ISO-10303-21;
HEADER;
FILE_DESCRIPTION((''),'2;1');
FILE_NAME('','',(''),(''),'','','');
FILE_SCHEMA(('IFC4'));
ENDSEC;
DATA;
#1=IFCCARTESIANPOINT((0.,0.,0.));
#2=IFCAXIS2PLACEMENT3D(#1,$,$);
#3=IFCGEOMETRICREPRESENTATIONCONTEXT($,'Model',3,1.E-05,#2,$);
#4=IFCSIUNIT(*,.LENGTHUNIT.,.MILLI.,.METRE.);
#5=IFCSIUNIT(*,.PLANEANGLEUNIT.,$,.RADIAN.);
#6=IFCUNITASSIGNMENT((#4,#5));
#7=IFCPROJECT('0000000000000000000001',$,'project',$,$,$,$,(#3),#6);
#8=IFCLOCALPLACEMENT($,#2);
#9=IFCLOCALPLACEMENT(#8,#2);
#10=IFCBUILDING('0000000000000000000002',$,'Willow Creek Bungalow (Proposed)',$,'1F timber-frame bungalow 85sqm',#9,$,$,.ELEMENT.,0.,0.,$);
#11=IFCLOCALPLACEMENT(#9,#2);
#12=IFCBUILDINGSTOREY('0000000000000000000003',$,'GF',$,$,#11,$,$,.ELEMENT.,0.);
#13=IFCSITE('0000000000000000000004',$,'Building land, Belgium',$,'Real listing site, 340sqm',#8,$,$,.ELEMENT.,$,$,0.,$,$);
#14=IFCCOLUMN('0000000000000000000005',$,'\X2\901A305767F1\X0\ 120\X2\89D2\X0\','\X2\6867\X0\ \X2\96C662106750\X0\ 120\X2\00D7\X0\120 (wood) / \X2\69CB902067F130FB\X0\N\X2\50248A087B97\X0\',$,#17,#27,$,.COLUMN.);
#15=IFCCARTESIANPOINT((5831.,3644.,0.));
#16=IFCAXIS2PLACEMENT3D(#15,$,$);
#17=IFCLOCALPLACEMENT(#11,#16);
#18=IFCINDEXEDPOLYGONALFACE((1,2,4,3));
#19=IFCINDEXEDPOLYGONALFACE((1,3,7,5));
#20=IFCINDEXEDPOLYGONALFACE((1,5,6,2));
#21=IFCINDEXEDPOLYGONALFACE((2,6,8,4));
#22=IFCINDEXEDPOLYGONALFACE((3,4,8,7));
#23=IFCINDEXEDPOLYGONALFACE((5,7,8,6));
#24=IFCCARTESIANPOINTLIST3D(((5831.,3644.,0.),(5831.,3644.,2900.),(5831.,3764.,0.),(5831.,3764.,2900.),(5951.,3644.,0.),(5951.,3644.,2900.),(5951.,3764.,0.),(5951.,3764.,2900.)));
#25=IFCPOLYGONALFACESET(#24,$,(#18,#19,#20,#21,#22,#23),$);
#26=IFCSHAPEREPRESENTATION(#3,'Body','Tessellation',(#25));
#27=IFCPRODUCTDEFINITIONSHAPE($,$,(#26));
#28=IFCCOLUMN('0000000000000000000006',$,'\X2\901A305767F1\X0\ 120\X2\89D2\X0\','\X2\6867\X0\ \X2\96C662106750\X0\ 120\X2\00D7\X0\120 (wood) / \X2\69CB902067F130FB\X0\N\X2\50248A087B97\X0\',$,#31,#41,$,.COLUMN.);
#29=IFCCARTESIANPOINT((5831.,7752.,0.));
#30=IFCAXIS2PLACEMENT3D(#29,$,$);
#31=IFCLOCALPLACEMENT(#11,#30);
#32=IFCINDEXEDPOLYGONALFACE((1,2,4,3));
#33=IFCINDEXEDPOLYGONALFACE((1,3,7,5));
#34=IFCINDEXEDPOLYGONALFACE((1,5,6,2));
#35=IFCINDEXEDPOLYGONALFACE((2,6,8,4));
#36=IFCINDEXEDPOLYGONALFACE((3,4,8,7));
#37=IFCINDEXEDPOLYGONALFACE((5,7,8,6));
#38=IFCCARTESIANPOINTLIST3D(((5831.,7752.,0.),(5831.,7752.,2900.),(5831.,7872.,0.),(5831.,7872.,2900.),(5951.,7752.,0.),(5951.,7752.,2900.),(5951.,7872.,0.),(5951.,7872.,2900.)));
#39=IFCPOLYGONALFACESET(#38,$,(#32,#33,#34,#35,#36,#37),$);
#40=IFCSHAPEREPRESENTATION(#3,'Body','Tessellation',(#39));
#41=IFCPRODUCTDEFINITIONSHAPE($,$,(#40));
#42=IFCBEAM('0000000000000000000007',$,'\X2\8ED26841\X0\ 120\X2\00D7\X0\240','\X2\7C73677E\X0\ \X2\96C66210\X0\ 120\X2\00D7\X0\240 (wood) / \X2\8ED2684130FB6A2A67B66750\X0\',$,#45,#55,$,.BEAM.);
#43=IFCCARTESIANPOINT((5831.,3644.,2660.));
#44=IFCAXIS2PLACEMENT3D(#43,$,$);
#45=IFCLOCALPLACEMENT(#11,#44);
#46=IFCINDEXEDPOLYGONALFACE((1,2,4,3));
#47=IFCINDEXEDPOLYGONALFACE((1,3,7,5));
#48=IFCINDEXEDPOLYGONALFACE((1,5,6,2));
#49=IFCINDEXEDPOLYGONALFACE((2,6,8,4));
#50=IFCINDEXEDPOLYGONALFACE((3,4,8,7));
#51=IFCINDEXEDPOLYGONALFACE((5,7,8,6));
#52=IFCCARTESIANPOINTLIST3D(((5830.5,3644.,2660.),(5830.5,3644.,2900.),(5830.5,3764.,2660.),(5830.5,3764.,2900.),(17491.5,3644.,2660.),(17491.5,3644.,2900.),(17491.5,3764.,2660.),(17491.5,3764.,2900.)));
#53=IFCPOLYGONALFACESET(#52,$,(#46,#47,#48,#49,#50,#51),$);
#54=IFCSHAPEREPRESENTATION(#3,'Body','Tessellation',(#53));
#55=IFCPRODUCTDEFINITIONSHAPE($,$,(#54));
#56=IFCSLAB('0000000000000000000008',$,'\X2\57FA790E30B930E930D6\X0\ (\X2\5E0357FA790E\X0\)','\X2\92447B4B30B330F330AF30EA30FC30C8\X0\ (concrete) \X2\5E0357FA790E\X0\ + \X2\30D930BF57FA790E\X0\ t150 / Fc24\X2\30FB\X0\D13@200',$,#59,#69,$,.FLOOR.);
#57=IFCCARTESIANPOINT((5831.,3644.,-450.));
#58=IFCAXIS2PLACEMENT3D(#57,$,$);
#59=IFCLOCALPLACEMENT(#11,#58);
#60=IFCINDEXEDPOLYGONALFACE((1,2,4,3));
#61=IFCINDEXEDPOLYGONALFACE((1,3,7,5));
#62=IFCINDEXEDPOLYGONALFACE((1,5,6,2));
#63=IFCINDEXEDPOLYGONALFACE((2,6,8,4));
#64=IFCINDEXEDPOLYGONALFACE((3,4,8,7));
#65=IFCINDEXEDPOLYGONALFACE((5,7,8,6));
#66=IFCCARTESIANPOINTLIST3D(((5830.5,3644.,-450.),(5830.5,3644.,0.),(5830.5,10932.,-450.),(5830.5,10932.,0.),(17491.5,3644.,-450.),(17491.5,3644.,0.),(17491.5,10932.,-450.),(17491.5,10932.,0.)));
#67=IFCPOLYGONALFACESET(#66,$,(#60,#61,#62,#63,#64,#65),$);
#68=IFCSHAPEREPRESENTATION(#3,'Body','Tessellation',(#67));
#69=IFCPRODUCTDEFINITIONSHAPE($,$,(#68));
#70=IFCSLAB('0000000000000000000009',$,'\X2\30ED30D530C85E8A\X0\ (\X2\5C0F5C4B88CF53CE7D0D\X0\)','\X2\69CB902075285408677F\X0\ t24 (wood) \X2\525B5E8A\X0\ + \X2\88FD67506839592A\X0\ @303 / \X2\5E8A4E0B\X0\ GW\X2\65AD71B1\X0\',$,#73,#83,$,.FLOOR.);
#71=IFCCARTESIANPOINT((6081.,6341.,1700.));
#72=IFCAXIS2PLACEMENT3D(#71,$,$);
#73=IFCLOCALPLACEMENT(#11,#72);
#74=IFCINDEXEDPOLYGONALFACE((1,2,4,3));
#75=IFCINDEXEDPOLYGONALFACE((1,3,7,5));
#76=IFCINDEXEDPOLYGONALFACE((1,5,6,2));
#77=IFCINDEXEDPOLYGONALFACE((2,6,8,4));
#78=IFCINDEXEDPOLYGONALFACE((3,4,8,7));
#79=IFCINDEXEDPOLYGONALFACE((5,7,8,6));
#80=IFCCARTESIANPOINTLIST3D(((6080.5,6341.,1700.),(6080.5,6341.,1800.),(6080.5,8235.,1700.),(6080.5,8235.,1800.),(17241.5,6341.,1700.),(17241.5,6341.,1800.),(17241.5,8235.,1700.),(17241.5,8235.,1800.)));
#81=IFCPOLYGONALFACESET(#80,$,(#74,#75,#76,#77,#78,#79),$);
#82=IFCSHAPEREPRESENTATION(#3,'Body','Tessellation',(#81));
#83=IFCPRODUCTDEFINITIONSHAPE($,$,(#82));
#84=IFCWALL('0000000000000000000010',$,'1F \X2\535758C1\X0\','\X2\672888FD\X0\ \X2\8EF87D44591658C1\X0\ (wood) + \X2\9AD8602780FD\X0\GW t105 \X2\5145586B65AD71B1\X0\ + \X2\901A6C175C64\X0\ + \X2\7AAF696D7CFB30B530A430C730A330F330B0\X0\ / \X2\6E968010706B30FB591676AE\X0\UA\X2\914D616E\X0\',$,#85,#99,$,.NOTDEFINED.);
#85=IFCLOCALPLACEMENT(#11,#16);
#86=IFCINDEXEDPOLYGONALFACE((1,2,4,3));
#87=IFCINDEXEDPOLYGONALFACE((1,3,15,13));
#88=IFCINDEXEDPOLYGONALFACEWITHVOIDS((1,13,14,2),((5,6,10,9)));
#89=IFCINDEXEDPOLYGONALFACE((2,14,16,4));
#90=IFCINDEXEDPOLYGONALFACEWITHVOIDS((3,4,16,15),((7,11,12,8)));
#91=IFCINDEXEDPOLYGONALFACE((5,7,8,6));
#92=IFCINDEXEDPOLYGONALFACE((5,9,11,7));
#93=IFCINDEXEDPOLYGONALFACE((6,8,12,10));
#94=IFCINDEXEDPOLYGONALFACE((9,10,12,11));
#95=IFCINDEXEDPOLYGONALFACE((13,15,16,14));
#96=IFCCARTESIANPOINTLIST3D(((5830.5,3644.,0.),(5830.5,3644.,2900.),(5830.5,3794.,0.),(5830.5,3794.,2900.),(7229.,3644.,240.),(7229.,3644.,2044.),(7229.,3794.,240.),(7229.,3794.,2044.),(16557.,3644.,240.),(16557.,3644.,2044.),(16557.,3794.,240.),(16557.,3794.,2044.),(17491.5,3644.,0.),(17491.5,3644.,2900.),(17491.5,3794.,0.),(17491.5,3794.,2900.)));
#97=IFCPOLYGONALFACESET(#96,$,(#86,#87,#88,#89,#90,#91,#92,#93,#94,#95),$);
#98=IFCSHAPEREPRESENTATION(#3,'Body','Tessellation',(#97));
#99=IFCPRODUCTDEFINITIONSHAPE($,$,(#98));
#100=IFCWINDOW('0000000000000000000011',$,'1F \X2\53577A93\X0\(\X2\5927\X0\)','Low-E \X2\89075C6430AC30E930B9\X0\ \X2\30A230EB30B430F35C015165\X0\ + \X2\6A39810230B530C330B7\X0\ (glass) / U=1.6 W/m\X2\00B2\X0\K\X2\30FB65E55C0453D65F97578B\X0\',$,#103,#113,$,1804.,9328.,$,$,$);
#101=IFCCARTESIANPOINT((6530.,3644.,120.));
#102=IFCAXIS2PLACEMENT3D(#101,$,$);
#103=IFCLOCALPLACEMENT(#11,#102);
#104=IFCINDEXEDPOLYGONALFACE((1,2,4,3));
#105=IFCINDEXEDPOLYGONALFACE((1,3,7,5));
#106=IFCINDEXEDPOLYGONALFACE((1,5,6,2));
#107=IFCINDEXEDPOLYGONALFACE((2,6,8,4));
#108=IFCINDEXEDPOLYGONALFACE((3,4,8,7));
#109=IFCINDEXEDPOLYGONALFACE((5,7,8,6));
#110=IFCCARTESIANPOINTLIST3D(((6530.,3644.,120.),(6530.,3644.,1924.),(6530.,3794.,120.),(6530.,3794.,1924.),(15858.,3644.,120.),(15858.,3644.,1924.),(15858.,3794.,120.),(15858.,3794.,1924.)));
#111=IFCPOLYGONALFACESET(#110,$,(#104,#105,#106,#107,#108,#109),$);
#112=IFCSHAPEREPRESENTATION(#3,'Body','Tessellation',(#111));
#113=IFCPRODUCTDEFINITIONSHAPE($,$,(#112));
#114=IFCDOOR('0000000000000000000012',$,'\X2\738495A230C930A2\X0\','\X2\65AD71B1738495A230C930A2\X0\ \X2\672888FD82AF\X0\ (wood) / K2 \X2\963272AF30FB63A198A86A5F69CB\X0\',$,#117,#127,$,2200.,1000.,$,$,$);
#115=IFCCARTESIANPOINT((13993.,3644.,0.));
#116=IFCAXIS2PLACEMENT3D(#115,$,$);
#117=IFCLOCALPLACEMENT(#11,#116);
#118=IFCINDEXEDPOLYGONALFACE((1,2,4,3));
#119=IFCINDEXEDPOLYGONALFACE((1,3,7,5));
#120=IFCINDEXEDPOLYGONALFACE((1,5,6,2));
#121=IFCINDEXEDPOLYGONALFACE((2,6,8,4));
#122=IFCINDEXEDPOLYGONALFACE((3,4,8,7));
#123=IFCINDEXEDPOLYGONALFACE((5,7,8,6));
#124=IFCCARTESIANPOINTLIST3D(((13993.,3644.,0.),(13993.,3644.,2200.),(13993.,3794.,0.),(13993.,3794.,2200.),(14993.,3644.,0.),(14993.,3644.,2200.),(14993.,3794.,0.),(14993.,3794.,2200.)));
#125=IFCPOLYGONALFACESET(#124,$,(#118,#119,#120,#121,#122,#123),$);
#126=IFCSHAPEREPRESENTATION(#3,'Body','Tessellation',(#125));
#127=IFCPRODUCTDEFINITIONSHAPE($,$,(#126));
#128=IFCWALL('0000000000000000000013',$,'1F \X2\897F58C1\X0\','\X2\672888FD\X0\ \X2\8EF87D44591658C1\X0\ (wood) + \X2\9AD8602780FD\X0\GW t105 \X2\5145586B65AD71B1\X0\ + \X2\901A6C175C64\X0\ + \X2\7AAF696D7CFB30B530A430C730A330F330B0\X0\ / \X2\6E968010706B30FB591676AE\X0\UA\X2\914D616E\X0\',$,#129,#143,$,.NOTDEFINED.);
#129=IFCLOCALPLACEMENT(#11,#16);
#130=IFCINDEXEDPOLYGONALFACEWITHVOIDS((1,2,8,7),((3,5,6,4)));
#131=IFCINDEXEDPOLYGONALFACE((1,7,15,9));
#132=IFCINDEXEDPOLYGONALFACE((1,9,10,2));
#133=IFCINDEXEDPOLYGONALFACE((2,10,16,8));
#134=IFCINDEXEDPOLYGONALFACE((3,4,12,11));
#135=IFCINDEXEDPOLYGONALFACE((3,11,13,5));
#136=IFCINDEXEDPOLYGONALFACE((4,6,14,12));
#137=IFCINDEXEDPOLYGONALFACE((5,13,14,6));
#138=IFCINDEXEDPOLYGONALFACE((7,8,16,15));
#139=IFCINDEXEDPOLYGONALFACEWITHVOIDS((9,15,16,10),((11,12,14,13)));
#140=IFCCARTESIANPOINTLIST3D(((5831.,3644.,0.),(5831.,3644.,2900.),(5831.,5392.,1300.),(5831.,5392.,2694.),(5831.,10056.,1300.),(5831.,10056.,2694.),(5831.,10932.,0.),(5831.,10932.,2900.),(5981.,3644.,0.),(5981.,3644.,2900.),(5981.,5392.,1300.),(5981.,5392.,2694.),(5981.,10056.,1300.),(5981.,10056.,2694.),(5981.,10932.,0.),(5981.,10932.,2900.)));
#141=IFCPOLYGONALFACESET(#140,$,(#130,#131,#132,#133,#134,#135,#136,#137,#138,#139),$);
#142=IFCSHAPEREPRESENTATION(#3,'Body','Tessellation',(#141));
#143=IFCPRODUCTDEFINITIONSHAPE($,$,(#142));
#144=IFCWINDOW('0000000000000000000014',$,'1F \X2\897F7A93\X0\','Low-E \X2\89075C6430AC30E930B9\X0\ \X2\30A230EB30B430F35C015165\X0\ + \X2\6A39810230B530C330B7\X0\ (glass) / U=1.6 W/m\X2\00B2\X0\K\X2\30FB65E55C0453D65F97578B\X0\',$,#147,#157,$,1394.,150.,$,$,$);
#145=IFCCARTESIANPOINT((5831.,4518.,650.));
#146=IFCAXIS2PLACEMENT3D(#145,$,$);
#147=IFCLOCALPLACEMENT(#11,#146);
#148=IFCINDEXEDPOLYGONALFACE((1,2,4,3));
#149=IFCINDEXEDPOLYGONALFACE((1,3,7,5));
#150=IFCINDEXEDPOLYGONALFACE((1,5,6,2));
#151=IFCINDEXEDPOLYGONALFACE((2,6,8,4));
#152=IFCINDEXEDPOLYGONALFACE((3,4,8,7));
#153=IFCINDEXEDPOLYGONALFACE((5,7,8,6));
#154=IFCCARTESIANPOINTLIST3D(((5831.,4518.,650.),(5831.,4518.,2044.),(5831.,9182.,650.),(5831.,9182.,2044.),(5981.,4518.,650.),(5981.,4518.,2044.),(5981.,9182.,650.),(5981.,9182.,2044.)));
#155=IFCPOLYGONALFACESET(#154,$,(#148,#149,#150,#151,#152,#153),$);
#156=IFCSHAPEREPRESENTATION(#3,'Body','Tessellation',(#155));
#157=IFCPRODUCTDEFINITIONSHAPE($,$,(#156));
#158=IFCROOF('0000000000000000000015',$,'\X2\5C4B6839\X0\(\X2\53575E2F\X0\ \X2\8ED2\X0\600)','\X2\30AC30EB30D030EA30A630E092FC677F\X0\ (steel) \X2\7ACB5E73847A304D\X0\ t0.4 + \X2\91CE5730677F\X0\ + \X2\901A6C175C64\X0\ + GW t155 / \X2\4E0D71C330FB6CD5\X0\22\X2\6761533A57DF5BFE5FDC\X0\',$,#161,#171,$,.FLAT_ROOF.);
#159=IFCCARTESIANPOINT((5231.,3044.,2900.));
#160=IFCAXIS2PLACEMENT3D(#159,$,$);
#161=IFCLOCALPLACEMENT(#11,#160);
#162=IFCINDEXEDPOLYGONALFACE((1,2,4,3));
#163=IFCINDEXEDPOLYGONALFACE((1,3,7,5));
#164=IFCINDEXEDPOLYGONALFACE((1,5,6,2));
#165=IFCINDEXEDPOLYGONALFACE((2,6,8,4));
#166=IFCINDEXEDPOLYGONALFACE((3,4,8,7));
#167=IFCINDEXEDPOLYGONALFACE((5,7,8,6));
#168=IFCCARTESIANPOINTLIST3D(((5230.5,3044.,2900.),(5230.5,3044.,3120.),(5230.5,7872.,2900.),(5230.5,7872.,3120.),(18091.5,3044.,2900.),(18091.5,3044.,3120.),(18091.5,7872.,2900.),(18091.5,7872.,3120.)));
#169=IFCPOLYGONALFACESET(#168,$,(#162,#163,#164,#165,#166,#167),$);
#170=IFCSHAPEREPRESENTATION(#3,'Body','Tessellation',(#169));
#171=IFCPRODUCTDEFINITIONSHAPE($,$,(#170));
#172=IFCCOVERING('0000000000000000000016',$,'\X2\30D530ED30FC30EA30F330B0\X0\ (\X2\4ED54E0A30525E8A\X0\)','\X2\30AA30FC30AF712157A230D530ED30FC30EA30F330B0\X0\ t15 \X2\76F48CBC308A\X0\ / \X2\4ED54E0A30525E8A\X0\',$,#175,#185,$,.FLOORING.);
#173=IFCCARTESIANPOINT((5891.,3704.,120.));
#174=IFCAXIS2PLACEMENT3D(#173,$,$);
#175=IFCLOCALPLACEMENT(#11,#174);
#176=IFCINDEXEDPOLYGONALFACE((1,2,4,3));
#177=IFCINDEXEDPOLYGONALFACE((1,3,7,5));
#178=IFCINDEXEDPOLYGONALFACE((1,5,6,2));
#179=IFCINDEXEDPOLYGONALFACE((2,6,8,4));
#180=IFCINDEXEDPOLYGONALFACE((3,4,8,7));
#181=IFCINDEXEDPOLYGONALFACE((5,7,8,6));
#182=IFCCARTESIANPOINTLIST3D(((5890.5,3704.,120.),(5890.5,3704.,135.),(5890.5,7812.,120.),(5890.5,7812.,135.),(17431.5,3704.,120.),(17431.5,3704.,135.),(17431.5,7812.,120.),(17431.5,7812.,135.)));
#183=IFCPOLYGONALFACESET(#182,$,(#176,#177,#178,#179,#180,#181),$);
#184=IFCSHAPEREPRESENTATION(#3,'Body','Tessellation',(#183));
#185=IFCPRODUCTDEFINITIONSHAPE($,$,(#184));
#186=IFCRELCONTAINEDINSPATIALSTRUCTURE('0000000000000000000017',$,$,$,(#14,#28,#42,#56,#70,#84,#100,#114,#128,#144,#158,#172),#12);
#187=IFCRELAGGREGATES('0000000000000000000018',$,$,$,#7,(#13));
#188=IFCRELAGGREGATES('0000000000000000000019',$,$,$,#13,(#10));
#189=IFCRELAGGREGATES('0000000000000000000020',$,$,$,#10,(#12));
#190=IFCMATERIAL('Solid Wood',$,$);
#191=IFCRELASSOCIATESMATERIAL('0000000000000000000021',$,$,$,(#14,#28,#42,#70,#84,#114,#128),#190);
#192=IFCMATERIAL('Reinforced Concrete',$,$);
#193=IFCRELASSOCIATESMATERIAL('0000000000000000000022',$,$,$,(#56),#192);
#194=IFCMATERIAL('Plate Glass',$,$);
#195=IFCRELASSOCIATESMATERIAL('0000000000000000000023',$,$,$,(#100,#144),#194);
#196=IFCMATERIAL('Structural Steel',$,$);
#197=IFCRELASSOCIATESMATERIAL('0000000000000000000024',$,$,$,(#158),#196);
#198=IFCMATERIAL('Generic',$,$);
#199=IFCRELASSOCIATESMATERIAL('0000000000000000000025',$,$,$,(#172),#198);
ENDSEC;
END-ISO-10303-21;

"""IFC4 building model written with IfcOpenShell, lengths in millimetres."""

from ifc_helpers import new_model, si_unit, frame, frame_2d, origin, place, context, project, spatial, rectangle, extrude, material, element, fill, save


model = new_model("IFC4")

# Units and contexts
model_context = context("Model", 3, precision=1e-05, world=origin())
ifc_project = project(units=[si_unit("LENGTHUNIT", "METRE", prefix="MILLI"), si_unit("PLANEANGLEUNIT", "RADIAN")], contexts=[model_context])

# Site, building, storey
site_placement = place(None, origin())
site = spatial("IfcSite", under=ifc_project, at=site_placement, Name="Building land, Belgium", ObjectType="Real listing site, 340sqm", CompositionType="ELEMENT", RefElevation=0.0)
building_placement = place(site_placement, origin())
building = spatial("IfcBuilding", under=site, at=building_placement, Name="Willow Creek Bungalow (Proposed)", ObjectType="1F timber-frame bungalow 85sqm", CompositionType="ELEMENT", ElevationOfRefHeight=0.0, ElevationOfTerrain=0.0)
storey_placement = place(building_placement, origin())
storey = spatial("IfcBuildingStorey", under=building, at=storey_placement, Name="GF", CompositionType="ELEMENT", Elevation=0.0)

# Columns
ifc_material_1 = material(Name="Solid Wood")
column_1_placement = place(storey_placement, frame((5831.0, 3644.0, 0.0)))
element("IfcColumn", 1, at=column_1_placement, inside=storey, material=ifc_material_1, Name="通し柱 120角", Description="桧 集成材 120×120 (wood) / 構造柱・N値計算", PredefinedType="COLUMN", context=model_context, shape_type="SweptSolid", body=[
    extrude(rectangle(XDim=120.0, YDim=120.0, at=frame_2d((60.0, 60.0))), frame((5831.0, 3644.0, 0.0)), (0.0, 0.0, 1.0), 2900.0),
])
column_2_placement = place(storey_placement, frame((5831.0, 7752.0, 0.0)))
element("IfcColumn", 2, at=column_2_placement, inside=storey, material=ifc_material_1, Name="通し柱 120角", Description="桧 集成材 120×120 (wood) / 構造柱・N値計算", PredefinedType="COLUMN", context=model_context, shape_type="SweptSolid", body=[
    extrude(rectangle(XDim=120.0, YDim=120.0, at=frame_2d((60.0, 60.0))), frame((5831.0, 7752.0, 0.0)), (0.0, 0.0, 1.0), 2900.0),
])

# Beam
beam_1_placement = place(storey_placement, frame((5831.0, 3644.0, 2660.0)))
element("IfcBeam", 3, at=beam_1_placement, inside=storey, material=ifc_material_1, Name="軒桁 120×240", Description="米松 集成 120×240 (wood) / 軒桁・横架材", PredefinedType="BEAM", context=model_context, shape_type="SweptSolid", body=[
    extrude(rectangle(XDim=11661.0, YDim=120.0, at=frame_2d((5830.0, 60.0))), frame((5831.0, 3644.0, 2660.0)), (0.0, 0.0, 1.0), 240.0),
])

# Slabs
ifc_material_2 = material(Name="Reinforced Concrete")
slab_1_placement = place(storey_placement, frame((5831.0, 3644.0, -450.0)))
element("IfcSlab", 4, at=slab_1_placement, inside=storey, material=ifc_material_2, Name="基礎スラブ (布基礎)", Description="鉄筋コンクリート (concrete) 布基礎 + ベタ基礎 t150 / Fc24・D13@200", PredefinedType="FLOOR", context=model_context, shape_type="SweptSolid", body=[
    extrude(rectangle(XDim=11661.0, YDim=7288.0, at=frame_2d((5830.0, 3644.0))), frame((5831.0, 3644.0, -450.0)), (0.0, 0.0, 1.0), 450.0),
])
slab_2_placement = place(storey_placement, frame((6081.0, 6341.0, 1700.0)))
element("IfcSlab", 5, at=slab_2_placement, inside=storey, material=ifc_material_1, Name="ロフト床 (小屋裏収納)", Description="構造用合板 t24 (wood) 剛床 + 製材根太 @303 / 床下 GW断熱", PredefinedType="FLOOR", context=model_context, shape_type="SweptSolid", body=[
    extrude(rectangle(XDim=11161.0, YDim=1894.0, at=frame_2d((5580.0, 947.0))), frame((6081.0, 6341.0, 1700.0)), (0.0, 0.0, 1.0), 100.0),
])

# Wall, openings, window, door
wall_1_placement = place(storey_placement, frame((5831.0, 3644.0, 0.0)))
wall_1 = element("IfcWall", 6, at=wall_1_placement, inside=storey, material=ifc_material_1, Name="1F 南壁", Description="木製 軸組外壁 (wood) + 高性能GW t105 充填断熱 + 通気層 + 窯業系サイディング / 準耐火・外皮UA配慮", PredefinedType="NOTDEFINED", context=model_context, shape_type="SweptSolid", body=[
    extrude(rectangle(XDim=11661.0, YDim=150.0, at=frame_2d((5830.0, 75.0))), frame((5831.0, 3644.0, 0.0)), (0.0, 0.0, 1.0), 2900.0),
])
opening_1_placement = place(storey_placement, frame((6530.0, 3644.0, 120.0)))
opening_1 = element("IfcOpeningElement", 7, at=opening_1_placement, cuts=wall_1, PredefinedType="NOTDEFINED", context=model_context, shape_type="SweptSolid", body=[
    extrude(rectangle(XDim=9328.0, YDim=150.0, at=frame_2d((4664.0, 75.0))), frame((6530.0, 3644.0, 120.0)), (0.0, 0.0, 1.0), 1804.0),
])
opening_2_placement = place(storey_placement, frame((13993.0, 3644.0, 0.0)))
opening_2 = element("IfcOpeningElement", 8, at=opening_2_placement, cuts=wall_1, PredefinedType="NOTDEFINED", context=model_context, shape_type="SweptSolid", body=[
    extrude(rectangle(XDim=1000.0, YDim=150.0, at=frame_2d((500.0, 75.0))), frame((13993.0, 3644.0, 0.0)), (0.0, 0.0, 1.0), 2200.0),
])
ifc_material_3 = material(Name="Plate Glass")
window_1_placement = place(storey_placement, frame((6530.0, 3644.0, 120.0)))
window_1 = element("IfcWindow", 9, at=window_1_placement, inside=storey, material=ifc_material_3, Name="1F 南窓(大)", Description="Low-E 複層ガラス アルゴン封入 + 樹脂サッシ (glass) / U=1.6 W/m²K・日射取得型", OverallHeight=1804.0, OverallWidth=9328.0, context=model_context, shape_type="SweptSolid", body=[
    extrude(rectangle(XDim=9328.0, YDim=150.0, at=frame_2d((4664.0, 75.0))), frame((6530.0, 3644.0, 120.0)), (0.0, 0.0, 1.0), 1804.0),
])
fill(opening_1, window_1)
door_placement = place(storey_placement, frame((13993.0, 3644.0, 0.0)))
door = element("IfcDoor", 10, at=door_placement, inside=storey, material=ifc_material_1, Name="玄関ドア", Description="断熱玄関ドア 木製芯 (wood) / K2 防犯・採風機構", OverallHeight=2200.0, OverallWidth=1000.0, context=model_context, shape_type="SweptSolid", body=[
    extrude(rectangle(XDim=1000.0, YDim=150.0, at=frame_2d((500.0, 75.0))), frame((13993.0, 3644.0, 0.0)), (0.0, 0.0, 1.0), 2200.0),
])
fill(opening_2, door)

# Wall, opening, window
wall_2_placement = place(storey_placement, frame((5831.0, 3644.0, 0.0)))
wall_2 = element("IfcWall", 11, at=wall_2_placement, inside=storey, material=ifc_material_1, Name="1F 西壁", Description="木製 軸組外壁 (wood) + 高性能GW t105 充填断熱 + 通気層 + 窯業系サイディング / 準耐火・外皮UA配慮", PredefinedType="NOTDEFINED", context=model_context, shape_type="SweptSolid", body=[
    extrude(rectangle(XDim=150.0, YDim=7288.0, at=frame_2d((75.0, 3644.0))), frame((5831.0, 3644.0, 0.0)), (0.0, 0.0, 1.0), 2900.0),
])
opening_3_placement = place(storey_placement, frame((5831.0, 4518.0, 650.0)))
opening_3 = element("IfcOpeningElement", 12, at=opening_3_placement, cuts=wall_2, PredefinedType="NOTDEFINED", context=model_context, shape_type="SweptSolid", body=[
    extrude(rectangle(XDim=150.0, YDim=4664.0, at=frame_2d((75.0, 2332.0))), frame((5831.0, 4518.0, 650.0)), (0.0, 0.0, 1.0), 1394.0),
])
window_2_placement = place(storey_placement, frame((5831.0, 4518.0, 650.0)))
window_2 = element("IfcWindow", 13, at=window_2_placement, inside=storey, material=ifc_material_3, Name="1F 西窓", Description="Low-E 複層ガラス アルゴン封入 + 樹脂サッシ (glass) / U=1.6 W/m²K・日射取得型", OverallHeight=1394.0, OverallWidth=150.0, context=model_context, shape_type="SweptSolid", body=[
    extrude(rectangle(XDim=150.0, YDim=4664.0, at=frame_2d((75.0, 2332.0))), frame((5831.0, 4518.0, 650.0)), (0.0, 0.0, 1.0), 1394.0),
])
fill(opening_3, window_2)

# Roof
ifc_material_4 = material(Name="Structural Steel")
roof_placement = place(storey_placement, frame((5231.0, 3044.0, 2900.0)))
element("IfcRoof", 14, at=roof_placement, inside=storey, material=ifc_material_4, Name="屋根(南帯 軒600)", Description="ガルバリウム鋼板 (steel) 立平葺き t0.4 + 野地板 + 通気層 + GW t155 / 不燃・法22条区域対応", PredefinedType="FLAT_ROOF", context=model_context, shape_type="SweptSolid", body=[
    extrude(rectangle(XDim=12861.0, YDim=4828.0, at=frame_2d((6430.0, 2414.0))), frame((5231.0, 3044.0, 2900.0)), (0.0, 0.0, 1.0), 220.0),
])

# Covering
ifc_material_5 = material(Name="Generic")
covering_1_placement = place(storey_placement, frame((5891.0, 3704.0, 120.0)))
element("IfcCovering", 15, at=covering_1_placement, inside=storey, material=ifc_material_5, Name="フローリング (仕上げ床)", Description="オーク無垢フローリング t15 直貼り / 仕上げ床", PredefinedType="FLOORING", context=model_context, shape_type="SweptSolid", body=[
    extrude(rectangle(XDim=11541.0, YDim=4108.0, at=frame_2d((5770.0, 2054.0))), frame((5891.0, 3704.0, 120.0)), (0.0, 0.0, 1.0), 15.0),
])

save(model, "model.ifc")
